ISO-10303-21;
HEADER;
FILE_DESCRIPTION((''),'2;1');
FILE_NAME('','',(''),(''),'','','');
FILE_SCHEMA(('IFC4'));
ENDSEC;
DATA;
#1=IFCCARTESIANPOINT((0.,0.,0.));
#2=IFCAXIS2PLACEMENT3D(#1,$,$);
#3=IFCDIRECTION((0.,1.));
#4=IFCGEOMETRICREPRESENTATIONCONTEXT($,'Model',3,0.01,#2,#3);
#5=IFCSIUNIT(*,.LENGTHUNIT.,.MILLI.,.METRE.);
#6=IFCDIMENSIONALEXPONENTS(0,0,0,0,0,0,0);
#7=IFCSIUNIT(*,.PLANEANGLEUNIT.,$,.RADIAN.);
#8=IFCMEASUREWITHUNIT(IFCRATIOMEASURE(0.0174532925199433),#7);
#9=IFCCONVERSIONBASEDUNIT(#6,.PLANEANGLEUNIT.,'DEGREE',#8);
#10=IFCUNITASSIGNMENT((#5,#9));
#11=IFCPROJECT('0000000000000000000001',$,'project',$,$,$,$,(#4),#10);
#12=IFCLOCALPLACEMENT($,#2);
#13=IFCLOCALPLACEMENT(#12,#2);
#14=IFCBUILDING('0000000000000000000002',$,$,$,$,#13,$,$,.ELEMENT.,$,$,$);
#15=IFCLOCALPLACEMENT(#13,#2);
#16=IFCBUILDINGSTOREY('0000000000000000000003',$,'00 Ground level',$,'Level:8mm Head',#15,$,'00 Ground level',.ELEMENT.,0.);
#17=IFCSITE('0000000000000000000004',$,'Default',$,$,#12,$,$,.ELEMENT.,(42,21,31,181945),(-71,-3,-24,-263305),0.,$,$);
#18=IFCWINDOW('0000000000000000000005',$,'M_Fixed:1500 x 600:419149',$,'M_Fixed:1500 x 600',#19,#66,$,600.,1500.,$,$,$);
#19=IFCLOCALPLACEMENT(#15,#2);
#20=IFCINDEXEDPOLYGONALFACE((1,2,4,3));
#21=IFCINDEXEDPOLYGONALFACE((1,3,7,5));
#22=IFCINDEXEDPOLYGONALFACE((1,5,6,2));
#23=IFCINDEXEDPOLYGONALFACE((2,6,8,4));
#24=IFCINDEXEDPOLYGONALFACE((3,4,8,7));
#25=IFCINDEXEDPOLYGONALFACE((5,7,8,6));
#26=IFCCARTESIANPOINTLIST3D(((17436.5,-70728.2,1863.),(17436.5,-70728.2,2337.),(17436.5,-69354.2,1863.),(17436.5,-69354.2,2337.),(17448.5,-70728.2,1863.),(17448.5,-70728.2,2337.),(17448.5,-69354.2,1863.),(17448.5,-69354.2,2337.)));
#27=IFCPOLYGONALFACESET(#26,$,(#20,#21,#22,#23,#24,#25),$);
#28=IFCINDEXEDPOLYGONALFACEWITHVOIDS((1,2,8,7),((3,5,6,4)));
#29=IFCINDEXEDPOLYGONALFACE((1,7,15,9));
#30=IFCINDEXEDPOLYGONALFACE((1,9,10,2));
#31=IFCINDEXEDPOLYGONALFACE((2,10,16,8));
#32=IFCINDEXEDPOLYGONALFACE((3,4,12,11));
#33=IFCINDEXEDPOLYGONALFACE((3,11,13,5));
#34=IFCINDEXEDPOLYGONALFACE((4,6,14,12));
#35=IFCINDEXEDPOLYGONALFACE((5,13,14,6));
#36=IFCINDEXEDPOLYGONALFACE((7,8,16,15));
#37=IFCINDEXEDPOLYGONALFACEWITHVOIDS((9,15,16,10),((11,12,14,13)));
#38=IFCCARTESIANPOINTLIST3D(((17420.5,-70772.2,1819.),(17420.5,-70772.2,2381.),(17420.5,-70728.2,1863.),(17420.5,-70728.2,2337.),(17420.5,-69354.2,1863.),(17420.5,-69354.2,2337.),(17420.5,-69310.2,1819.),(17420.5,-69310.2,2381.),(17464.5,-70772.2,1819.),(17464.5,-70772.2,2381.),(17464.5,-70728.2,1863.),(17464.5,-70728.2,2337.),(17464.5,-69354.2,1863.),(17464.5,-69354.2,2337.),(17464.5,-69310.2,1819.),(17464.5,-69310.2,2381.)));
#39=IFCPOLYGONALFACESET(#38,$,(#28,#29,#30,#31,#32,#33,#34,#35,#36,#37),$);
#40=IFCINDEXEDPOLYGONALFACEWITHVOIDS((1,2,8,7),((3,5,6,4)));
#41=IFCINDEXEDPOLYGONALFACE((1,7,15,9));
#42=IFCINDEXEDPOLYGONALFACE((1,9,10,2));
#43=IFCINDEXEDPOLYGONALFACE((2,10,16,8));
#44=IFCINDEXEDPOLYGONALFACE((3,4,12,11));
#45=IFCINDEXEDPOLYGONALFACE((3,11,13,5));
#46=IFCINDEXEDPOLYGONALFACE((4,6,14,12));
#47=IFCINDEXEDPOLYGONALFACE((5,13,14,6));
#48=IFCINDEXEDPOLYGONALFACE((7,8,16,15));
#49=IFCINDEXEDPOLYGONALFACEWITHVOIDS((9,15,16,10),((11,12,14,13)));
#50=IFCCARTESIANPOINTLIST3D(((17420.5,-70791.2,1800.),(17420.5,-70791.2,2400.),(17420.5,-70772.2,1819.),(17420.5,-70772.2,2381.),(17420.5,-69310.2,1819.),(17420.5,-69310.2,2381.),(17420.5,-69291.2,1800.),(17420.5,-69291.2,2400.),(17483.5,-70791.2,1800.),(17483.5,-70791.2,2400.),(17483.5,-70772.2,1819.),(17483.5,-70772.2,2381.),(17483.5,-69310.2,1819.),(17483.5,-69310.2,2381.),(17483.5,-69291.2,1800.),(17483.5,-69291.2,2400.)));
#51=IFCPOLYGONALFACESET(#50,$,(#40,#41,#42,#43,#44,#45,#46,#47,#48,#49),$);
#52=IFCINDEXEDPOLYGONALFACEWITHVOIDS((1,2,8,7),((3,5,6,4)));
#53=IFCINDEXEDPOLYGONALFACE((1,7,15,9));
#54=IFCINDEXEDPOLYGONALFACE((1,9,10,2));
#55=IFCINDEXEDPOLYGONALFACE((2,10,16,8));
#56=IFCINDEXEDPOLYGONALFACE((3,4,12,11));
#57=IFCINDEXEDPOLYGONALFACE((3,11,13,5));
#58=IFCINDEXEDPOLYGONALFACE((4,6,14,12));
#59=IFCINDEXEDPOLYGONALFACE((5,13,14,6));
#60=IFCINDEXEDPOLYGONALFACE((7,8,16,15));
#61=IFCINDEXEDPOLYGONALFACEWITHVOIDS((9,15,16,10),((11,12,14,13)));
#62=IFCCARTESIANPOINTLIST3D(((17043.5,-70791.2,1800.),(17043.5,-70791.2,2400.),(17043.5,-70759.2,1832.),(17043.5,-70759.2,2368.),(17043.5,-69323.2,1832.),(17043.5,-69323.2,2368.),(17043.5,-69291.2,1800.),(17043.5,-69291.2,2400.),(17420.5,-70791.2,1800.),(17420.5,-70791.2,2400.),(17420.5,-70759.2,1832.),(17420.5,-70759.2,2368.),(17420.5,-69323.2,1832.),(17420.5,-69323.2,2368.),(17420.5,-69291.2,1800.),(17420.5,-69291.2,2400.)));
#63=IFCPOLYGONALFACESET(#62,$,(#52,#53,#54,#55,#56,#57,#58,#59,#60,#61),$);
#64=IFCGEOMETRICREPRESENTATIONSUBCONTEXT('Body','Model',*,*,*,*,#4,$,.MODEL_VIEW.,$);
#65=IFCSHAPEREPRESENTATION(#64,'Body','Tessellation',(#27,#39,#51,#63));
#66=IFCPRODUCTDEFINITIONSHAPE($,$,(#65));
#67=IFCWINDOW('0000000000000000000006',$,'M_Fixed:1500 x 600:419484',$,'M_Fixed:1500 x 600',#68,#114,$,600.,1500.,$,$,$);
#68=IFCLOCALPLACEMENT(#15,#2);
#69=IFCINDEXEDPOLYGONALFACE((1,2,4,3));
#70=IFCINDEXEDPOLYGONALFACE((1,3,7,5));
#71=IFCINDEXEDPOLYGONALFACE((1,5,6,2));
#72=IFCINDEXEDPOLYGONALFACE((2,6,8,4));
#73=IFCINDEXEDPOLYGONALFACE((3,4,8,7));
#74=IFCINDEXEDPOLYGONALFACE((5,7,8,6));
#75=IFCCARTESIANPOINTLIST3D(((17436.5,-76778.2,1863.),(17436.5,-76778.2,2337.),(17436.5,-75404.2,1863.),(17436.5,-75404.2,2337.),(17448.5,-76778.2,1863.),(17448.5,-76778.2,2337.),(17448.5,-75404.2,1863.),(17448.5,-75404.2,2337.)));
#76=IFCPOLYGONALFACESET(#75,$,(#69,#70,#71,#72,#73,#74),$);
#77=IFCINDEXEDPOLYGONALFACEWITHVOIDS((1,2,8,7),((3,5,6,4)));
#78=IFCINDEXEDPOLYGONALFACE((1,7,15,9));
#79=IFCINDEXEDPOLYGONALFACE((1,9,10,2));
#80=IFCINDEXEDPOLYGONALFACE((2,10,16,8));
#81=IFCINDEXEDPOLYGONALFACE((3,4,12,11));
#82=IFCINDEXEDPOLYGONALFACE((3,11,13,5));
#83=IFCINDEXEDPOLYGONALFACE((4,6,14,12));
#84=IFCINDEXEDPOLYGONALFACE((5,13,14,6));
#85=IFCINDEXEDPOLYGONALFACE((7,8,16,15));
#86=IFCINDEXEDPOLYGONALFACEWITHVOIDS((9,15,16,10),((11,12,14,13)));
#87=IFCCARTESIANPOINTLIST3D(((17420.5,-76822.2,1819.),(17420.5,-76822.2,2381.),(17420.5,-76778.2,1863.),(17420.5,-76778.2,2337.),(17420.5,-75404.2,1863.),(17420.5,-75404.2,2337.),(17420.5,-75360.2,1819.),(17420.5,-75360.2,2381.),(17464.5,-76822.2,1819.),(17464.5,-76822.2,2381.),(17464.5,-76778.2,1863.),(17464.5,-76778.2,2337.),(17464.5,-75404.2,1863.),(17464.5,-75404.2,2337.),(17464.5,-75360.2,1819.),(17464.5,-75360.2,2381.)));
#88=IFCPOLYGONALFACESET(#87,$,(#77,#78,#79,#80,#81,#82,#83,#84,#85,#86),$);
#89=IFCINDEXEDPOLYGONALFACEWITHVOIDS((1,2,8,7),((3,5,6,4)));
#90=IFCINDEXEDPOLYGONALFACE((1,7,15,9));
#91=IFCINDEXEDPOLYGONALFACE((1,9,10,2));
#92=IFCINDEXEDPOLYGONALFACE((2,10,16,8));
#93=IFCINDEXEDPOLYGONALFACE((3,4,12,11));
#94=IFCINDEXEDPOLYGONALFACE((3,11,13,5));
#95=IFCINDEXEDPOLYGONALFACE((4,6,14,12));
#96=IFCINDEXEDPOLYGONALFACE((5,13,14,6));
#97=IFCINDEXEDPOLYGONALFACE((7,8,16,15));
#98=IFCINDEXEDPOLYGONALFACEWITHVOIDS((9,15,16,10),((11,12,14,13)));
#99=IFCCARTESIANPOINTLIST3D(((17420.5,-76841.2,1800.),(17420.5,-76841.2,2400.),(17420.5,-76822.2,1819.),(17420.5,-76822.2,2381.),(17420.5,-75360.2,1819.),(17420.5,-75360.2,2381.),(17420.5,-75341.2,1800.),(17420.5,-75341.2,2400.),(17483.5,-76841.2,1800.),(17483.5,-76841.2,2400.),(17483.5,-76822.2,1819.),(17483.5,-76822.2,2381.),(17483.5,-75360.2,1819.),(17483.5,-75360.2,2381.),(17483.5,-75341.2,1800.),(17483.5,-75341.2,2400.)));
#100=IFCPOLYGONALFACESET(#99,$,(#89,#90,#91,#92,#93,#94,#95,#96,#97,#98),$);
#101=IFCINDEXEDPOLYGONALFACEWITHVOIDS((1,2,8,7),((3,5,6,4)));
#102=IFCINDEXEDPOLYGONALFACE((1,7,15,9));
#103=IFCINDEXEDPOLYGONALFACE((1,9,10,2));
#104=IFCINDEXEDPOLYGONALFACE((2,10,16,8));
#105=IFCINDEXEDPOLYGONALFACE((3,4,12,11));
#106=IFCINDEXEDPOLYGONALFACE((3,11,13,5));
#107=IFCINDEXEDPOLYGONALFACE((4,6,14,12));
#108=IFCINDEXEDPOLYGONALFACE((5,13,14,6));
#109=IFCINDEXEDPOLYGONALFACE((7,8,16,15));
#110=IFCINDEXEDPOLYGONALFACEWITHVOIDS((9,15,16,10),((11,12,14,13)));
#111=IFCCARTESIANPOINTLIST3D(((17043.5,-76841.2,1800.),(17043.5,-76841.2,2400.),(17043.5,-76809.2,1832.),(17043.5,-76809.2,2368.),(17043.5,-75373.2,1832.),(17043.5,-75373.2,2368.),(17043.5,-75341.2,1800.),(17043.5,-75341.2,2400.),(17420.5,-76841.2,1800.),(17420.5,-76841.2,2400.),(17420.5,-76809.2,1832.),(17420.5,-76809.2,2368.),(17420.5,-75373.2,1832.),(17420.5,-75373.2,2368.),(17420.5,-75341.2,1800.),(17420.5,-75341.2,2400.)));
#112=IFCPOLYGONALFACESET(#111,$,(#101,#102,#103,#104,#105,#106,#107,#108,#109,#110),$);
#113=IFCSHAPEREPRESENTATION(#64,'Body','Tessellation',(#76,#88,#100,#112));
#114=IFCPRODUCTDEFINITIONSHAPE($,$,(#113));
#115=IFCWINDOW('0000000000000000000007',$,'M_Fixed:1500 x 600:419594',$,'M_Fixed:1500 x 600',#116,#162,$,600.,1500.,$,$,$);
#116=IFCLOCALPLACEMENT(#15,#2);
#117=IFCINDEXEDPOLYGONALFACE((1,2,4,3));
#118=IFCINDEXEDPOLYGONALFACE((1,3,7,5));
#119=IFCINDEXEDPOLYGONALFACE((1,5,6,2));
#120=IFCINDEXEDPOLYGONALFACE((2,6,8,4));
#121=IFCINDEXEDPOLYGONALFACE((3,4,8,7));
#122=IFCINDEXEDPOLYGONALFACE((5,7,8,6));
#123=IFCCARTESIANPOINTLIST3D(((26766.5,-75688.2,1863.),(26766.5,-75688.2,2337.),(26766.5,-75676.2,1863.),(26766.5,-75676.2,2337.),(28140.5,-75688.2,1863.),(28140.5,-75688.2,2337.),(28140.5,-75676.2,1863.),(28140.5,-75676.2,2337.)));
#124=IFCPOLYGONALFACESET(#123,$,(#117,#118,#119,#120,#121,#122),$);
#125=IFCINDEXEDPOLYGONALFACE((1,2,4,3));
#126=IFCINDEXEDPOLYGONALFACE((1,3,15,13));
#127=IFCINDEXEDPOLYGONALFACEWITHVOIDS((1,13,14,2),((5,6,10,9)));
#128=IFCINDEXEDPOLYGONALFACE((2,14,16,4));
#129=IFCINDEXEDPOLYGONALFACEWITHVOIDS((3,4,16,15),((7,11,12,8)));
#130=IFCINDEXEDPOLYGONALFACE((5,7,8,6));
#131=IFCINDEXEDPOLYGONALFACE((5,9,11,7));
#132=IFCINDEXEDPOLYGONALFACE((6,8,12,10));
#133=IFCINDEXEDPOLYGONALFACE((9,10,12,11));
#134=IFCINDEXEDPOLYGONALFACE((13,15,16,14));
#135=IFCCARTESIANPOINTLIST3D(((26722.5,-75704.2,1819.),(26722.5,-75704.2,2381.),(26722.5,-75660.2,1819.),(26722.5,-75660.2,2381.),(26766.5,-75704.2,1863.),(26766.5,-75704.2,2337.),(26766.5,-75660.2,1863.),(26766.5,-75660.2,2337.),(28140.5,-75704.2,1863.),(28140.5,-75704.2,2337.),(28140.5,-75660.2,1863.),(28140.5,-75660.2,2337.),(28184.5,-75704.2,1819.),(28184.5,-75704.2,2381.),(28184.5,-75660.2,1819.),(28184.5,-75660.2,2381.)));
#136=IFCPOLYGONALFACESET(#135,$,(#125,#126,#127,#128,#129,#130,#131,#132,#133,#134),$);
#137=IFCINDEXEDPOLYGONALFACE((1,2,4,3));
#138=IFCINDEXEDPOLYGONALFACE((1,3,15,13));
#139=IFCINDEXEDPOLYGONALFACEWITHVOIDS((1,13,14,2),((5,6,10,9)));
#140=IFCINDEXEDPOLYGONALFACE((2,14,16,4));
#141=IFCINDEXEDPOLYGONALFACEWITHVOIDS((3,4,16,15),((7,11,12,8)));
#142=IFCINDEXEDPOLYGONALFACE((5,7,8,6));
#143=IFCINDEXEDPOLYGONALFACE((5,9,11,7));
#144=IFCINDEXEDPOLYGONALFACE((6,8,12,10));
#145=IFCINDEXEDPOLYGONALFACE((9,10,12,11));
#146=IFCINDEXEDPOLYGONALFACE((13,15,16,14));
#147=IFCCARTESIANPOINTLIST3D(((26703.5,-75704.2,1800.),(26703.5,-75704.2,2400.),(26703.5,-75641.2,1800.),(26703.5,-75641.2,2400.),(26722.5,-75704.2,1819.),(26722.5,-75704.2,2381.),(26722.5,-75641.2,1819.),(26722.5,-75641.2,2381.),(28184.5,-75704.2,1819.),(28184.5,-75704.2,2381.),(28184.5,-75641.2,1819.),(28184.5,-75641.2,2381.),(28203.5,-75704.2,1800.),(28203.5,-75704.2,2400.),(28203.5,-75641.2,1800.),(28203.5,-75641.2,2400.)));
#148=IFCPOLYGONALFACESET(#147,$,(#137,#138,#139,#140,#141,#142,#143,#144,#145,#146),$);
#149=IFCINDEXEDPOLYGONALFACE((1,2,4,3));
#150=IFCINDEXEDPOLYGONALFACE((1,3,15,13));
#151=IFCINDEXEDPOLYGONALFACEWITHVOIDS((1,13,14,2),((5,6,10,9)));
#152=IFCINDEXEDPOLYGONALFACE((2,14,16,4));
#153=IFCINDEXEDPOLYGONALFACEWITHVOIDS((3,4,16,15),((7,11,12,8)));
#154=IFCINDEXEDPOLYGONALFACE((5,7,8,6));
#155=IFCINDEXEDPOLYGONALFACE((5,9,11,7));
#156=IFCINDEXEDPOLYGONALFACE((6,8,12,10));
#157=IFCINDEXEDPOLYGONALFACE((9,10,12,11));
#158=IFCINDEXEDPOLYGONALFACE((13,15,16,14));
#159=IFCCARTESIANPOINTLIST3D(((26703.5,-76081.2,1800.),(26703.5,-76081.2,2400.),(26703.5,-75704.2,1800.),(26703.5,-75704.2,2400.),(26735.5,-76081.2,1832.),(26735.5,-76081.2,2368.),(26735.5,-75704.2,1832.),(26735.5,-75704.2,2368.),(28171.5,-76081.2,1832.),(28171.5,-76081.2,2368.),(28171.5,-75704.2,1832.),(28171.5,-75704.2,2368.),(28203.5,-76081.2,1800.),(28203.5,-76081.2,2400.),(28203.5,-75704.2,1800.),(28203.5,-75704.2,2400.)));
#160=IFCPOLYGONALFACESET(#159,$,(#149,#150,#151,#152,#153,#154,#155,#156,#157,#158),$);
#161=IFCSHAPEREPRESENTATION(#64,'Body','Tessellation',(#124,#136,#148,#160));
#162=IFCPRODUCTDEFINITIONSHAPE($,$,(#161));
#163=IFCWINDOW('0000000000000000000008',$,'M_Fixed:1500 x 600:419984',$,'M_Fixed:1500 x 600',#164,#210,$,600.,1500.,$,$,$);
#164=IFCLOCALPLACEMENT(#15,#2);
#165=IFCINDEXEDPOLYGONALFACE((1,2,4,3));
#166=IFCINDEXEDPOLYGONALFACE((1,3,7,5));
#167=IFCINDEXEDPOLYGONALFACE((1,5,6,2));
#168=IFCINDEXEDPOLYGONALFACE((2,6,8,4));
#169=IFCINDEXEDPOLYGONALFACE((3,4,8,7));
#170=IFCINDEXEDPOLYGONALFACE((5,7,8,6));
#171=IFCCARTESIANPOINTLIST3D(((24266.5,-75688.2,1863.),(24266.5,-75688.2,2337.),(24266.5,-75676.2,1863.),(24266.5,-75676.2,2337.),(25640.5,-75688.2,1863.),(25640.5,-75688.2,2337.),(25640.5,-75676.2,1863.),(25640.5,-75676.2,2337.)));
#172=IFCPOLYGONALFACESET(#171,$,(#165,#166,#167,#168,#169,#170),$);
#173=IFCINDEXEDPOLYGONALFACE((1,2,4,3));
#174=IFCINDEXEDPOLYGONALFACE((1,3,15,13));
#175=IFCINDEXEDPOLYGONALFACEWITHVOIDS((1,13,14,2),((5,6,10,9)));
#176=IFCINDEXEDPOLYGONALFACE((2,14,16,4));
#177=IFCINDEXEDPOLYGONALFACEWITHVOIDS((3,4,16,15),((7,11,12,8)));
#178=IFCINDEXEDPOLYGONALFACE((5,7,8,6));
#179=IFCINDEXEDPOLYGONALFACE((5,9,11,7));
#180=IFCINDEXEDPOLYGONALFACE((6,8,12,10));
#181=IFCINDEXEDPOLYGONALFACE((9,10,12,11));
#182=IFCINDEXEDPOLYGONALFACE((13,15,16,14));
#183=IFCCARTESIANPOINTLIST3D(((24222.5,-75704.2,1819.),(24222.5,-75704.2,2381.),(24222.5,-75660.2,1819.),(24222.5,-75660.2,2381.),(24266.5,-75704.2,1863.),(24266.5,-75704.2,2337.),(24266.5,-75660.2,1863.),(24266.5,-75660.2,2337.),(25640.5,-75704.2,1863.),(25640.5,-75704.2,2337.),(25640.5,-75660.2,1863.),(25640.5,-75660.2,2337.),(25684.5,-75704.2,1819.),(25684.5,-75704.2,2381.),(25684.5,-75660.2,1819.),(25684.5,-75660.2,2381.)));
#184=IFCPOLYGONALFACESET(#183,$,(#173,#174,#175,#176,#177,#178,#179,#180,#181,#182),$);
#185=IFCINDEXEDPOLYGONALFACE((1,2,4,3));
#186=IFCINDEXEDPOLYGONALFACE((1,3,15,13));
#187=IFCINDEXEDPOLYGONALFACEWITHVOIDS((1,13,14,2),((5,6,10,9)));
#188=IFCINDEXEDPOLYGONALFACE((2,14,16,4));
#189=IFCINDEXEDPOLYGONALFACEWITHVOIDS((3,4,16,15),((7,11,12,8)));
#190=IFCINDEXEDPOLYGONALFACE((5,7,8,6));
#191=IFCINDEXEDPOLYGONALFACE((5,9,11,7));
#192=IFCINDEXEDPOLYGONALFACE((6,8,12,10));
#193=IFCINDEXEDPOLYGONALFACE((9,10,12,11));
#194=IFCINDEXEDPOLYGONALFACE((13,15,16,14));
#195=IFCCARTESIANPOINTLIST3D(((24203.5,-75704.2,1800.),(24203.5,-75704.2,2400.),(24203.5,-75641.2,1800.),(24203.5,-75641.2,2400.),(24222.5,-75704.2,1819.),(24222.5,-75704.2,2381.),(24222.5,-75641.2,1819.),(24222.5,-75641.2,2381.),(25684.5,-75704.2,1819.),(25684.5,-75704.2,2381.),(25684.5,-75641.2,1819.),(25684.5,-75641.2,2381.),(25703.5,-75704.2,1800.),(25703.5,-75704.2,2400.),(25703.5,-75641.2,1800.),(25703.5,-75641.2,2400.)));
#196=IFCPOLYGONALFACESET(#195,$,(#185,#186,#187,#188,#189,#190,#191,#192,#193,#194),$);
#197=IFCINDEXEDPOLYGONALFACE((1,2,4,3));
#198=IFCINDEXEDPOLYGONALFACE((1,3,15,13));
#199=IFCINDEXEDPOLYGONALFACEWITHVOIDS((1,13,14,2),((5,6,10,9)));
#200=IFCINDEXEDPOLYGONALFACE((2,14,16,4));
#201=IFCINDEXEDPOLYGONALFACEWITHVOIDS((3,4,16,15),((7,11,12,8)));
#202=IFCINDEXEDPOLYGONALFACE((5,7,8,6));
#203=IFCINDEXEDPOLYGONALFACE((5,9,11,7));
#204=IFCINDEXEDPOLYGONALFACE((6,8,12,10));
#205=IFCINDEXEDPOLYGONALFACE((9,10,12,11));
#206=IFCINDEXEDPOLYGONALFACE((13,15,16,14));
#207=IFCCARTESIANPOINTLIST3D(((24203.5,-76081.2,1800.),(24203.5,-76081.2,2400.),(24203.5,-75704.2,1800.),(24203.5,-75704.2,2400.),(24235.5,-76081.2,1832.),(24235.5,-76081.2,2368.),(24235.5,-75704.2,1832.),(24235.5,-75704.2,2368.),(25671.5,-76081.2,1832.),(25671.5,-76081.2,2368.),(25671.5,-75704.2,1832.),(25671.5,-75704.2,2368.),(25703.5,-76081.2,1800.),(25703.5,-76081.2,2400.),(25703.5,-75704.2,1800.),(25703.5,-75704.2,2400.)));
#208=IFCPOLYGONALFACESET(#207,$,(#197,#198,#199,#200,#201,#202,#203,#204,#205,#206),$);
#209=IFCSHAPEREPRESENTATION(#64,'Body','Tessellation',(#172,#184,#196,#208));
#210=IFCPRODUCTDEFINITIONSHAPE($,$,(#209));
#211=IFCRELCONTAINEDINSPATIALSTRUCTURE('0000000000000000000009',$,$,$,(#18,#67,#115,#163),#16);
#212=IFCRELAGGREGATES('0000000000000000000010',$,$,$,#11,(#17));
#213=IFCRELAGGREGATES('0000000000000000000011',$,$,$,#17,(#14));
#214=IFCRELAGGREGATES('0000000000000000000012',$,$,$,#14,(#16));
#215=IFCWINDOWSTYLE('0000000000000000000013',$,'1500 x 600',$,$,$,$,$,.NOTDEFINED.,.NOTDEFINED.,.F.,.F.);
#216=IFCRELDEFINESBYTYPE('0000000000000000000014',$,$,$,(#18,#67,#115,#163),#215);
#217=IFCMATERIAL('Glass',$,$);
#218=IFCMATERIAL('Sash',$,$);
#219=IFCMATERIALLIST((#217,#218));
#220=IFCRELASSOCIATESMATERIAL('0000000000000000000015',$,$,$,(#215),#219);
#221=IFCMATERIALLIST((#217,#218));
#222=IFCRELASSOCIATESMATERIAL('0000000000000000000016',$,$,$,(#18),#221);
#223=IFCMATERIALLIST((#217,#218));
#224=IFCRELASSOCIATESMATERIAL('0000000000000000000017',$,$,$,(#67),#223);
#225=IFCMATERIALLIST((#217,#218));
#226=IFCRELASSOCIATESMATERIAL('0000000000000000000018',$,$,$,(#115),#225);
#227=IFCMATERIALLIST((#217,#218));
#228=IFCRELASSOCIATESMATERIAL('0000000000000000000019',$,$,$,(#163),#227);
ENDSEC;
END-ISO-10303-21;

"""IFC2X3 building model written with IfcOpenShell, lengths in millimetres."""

from ifc_helpers import new_model, entity, si_unit, converted_unit, direction, frame, origin, origin_2d_with_axis, place, context, subcontext, project, spatial, polyline, rectangle, outline, extrude, source, transform, mapped, material, material_list, type_object, type_shapes, element, save


model = new_model("IFC2X3")

# Units and contexts
model_context = context("Model", 3, precision=0.01, world=origin(), true_north=direction((0.0, 1.0)))
body_context = subcontext(model_context, "Body", "Model", "MODEL_VIEW")
ifc_project = project(units=[si_unit("LENGTHUNIT", "METRE", prefix="MILLI"), converted_unit("PLANEANGLEUNIT", "DEGREE", entity("IfcRatioMeasure", 0.0174532925199433), si_unit("PLANEANGLEUNIT", "RADIAN"), dimensions=[0, 0, 0, 0, 0, 0, 0])], contexts=[model_context])

# Site, building, storey
site_placement = place(None, origin())
site = spatial("IfcSite", under=ifc_project, at=site_placement, Name="Default", CompositionType="ELEMENT", RefLatitude=(42, 21, 31, 181945), RefLongitude=(-71, -3, -24, -263305), RefElevation=0.0)
building_placement = place(site_placement, origin())
building = spatial("IfcBuilding", under=site, at=building_placement, CompositionType="ELEMENT")
storey_placement = place(building_placement, origin())
storey = spatial("IfcBuildingStorey", under=building, at=storey_placement, Name="00 Ground level", ObjectType="Level:8mm Head", LongName="00 Ground level", CompositionType="ELEMENT", Elevation=0.0)

# Windows
ifc_material_1 = material(Name="Glass")
ifc_material_2 = material(Name="Sash")
ifc_material_list_1 = material_list([ifc_material_1, ifc_material_2])
ifc_material_list_2 = material_list([ifc_material_1, ifc_material_2])
window_style_1 = type_object("IfcWindowStyle", Name="1500 x 600", ConstructionType="NOTDEFINED", OperationType="NOTDEFINED", ParameterTakesPrecedence=False, Sizeable=False, material=ifc_material_list_2)
shared_shape_1 = source(origin(), body_context, "Body", "SweptSolid", [
    extrude(rectangle(XDim=12.0, YDim=1374.0, at=origin_2d_with_axis()), frame((750.0, 399.0, 63.0), z_axis=(0.0, 0.0, 1.0), x_axis=(0.0, -1.0, 0.0)), (0.0, 0.0, 1.0), 474.0),
    extrude(outline(polyline([(-731.0, -281.0), (731.0, -281.0), (731.0, 281.0), (-731.0, 281.0), (-731.0, -281.0)]), holes=[polyline([(-687.0, -237.0), (-687.0, 237.0), (687.0, 237.0), (687.0, -237.0), (-687.0, -237.0)])]), frame((750.0, 377.0, 300.0), z_axis=(0.0, 1.0, 0.0), x_axis=(1.0, 0.0, 0.0)), (0.0, 0.0, 1.0), 44.0),
    extrude(outline(polyline([(-750.0, -300.0), (750.0, -300.0), (750.0, 300.0), (-750.0, 300.0), (-750.0, -300.0)]), holes=[polyline([(-731.0, -281.0), (-731.0, 281.0), (731.0, 281.0), (731.0, -281.0), (-731.0, -281.0)])]), frame((750.0, 377.0, 300.0), z_axis=(0.0, 1.0, 0.0), x_axis=(1.0, 0.0, 0.0)), (0.0, 0.0, 1.0), 63.0),
    extrude(outline(polyline([(-750.0, -300.0), (750.0, -300.0), (750.0, 300.0), (-750.0, 300.0), (-750.0, -300.0)]), holes=[polyline([(-718.0, -268.0), (-718.0, 268.0), (718.0, 268.0), (718.0, -268.0), (-718.0, -268.0)])]), frame((750.0, 0.0, 300.0), z_axis=(0.0, 1.0, 0.0), x_axis=(1.0, 0.0, 0.0)), (0.0, 0.0, 1.0), 377.0),
])
type_shapes(window_style_1, [shared_shape_1])
window_1_placement = place(storey_placement, frame((17043.5, -69291.2, 1800.0), z_axis=(0.0, 0.0, 1.0), x_axis=(0.0, -1.0, 0.0)))
element("IfcWindow", 1, at=window_1_placement, inside=storey, type_object=window_style_1, material=ifc_material_list_1, Name="M_Fixed:1500 x 600:419149", ObjectType="M_Fixed:1500 x 600", OverallHeight=600.0, OverallWidth=1500.0, context=body_context, shape_type="MappedRepresentation", body=[
    mapped(shared_shape_1, transform((0.0, 0.0, 0.0), scale=1.0)),
])
ifc_material_list_3 = material_list([ifc_material_1, ifc_material_2])
window_2_placement = place(storey_placement, frame((17043.5, -75341.2, 1800.0), z_axis=(0.0, 0.0, 1.0), x_axis=(0.0, -1.0, 0.0)))
element("IfcWindow", 2, at=window_2_placement, inside=storey, type_object=window_style_1, material=ifc_material_list_3, Name="M_Fixed:1500 x 600:419484", ObjectType="M_Fixed:1500 x 600", OverallHeight=600.0, OverallWidth=1500.0, context=body_context, shape_type="MappedRepresentation", body=[
    mapped(shared_shape_1, transform((0.0, 0.0, 0.0), scale=1.0)),
])
ifc_material_list_4 = material_list([ifc_material_1, ifc_material_2])
window_3_placement = place(storey_placement, frame((26703.5, -76081.2, 1800.0)))
element("IfcWindow", 3, at=window_3_placement, inside=storey, type_object=window_style_1, material=ifc_material_list_4, Name="M_Fixed:1500 x 600:419594", ObjectType="M_Fixed:1500 x 600", OverallHeight=600.0, OverallWidth=1500.0, context=body_context, shape_type="MappedRepresentation", body=[
    mapped(shared_shape_1, transform((0.0, 0.0, 0.0), scale=1.0)),
])
ifc_material_list_5 = material_list([ifc_material_1, ifc_material_2])
window_4_placement = place(storey_placement, frame((24203.5, -76081.2, 1800.0)))
element("IfcWindow", 4, at=window_4_placement, inside=storey, type_object=window_style_1, material=ifc_material_list_5, Name="M_Fixed:1500 x 600:419984", ObjectType="M_Fixed:1500 x 600", OverallHeight=600.0, OverallWidth=1500.0, context=body_context, shape_type="MappedRepresentation", body=[
    mapped(shared_shape_1, transform((0.0, 0.0, 0.0), scale=1.0)),
])

save(model, "model.ifc")
